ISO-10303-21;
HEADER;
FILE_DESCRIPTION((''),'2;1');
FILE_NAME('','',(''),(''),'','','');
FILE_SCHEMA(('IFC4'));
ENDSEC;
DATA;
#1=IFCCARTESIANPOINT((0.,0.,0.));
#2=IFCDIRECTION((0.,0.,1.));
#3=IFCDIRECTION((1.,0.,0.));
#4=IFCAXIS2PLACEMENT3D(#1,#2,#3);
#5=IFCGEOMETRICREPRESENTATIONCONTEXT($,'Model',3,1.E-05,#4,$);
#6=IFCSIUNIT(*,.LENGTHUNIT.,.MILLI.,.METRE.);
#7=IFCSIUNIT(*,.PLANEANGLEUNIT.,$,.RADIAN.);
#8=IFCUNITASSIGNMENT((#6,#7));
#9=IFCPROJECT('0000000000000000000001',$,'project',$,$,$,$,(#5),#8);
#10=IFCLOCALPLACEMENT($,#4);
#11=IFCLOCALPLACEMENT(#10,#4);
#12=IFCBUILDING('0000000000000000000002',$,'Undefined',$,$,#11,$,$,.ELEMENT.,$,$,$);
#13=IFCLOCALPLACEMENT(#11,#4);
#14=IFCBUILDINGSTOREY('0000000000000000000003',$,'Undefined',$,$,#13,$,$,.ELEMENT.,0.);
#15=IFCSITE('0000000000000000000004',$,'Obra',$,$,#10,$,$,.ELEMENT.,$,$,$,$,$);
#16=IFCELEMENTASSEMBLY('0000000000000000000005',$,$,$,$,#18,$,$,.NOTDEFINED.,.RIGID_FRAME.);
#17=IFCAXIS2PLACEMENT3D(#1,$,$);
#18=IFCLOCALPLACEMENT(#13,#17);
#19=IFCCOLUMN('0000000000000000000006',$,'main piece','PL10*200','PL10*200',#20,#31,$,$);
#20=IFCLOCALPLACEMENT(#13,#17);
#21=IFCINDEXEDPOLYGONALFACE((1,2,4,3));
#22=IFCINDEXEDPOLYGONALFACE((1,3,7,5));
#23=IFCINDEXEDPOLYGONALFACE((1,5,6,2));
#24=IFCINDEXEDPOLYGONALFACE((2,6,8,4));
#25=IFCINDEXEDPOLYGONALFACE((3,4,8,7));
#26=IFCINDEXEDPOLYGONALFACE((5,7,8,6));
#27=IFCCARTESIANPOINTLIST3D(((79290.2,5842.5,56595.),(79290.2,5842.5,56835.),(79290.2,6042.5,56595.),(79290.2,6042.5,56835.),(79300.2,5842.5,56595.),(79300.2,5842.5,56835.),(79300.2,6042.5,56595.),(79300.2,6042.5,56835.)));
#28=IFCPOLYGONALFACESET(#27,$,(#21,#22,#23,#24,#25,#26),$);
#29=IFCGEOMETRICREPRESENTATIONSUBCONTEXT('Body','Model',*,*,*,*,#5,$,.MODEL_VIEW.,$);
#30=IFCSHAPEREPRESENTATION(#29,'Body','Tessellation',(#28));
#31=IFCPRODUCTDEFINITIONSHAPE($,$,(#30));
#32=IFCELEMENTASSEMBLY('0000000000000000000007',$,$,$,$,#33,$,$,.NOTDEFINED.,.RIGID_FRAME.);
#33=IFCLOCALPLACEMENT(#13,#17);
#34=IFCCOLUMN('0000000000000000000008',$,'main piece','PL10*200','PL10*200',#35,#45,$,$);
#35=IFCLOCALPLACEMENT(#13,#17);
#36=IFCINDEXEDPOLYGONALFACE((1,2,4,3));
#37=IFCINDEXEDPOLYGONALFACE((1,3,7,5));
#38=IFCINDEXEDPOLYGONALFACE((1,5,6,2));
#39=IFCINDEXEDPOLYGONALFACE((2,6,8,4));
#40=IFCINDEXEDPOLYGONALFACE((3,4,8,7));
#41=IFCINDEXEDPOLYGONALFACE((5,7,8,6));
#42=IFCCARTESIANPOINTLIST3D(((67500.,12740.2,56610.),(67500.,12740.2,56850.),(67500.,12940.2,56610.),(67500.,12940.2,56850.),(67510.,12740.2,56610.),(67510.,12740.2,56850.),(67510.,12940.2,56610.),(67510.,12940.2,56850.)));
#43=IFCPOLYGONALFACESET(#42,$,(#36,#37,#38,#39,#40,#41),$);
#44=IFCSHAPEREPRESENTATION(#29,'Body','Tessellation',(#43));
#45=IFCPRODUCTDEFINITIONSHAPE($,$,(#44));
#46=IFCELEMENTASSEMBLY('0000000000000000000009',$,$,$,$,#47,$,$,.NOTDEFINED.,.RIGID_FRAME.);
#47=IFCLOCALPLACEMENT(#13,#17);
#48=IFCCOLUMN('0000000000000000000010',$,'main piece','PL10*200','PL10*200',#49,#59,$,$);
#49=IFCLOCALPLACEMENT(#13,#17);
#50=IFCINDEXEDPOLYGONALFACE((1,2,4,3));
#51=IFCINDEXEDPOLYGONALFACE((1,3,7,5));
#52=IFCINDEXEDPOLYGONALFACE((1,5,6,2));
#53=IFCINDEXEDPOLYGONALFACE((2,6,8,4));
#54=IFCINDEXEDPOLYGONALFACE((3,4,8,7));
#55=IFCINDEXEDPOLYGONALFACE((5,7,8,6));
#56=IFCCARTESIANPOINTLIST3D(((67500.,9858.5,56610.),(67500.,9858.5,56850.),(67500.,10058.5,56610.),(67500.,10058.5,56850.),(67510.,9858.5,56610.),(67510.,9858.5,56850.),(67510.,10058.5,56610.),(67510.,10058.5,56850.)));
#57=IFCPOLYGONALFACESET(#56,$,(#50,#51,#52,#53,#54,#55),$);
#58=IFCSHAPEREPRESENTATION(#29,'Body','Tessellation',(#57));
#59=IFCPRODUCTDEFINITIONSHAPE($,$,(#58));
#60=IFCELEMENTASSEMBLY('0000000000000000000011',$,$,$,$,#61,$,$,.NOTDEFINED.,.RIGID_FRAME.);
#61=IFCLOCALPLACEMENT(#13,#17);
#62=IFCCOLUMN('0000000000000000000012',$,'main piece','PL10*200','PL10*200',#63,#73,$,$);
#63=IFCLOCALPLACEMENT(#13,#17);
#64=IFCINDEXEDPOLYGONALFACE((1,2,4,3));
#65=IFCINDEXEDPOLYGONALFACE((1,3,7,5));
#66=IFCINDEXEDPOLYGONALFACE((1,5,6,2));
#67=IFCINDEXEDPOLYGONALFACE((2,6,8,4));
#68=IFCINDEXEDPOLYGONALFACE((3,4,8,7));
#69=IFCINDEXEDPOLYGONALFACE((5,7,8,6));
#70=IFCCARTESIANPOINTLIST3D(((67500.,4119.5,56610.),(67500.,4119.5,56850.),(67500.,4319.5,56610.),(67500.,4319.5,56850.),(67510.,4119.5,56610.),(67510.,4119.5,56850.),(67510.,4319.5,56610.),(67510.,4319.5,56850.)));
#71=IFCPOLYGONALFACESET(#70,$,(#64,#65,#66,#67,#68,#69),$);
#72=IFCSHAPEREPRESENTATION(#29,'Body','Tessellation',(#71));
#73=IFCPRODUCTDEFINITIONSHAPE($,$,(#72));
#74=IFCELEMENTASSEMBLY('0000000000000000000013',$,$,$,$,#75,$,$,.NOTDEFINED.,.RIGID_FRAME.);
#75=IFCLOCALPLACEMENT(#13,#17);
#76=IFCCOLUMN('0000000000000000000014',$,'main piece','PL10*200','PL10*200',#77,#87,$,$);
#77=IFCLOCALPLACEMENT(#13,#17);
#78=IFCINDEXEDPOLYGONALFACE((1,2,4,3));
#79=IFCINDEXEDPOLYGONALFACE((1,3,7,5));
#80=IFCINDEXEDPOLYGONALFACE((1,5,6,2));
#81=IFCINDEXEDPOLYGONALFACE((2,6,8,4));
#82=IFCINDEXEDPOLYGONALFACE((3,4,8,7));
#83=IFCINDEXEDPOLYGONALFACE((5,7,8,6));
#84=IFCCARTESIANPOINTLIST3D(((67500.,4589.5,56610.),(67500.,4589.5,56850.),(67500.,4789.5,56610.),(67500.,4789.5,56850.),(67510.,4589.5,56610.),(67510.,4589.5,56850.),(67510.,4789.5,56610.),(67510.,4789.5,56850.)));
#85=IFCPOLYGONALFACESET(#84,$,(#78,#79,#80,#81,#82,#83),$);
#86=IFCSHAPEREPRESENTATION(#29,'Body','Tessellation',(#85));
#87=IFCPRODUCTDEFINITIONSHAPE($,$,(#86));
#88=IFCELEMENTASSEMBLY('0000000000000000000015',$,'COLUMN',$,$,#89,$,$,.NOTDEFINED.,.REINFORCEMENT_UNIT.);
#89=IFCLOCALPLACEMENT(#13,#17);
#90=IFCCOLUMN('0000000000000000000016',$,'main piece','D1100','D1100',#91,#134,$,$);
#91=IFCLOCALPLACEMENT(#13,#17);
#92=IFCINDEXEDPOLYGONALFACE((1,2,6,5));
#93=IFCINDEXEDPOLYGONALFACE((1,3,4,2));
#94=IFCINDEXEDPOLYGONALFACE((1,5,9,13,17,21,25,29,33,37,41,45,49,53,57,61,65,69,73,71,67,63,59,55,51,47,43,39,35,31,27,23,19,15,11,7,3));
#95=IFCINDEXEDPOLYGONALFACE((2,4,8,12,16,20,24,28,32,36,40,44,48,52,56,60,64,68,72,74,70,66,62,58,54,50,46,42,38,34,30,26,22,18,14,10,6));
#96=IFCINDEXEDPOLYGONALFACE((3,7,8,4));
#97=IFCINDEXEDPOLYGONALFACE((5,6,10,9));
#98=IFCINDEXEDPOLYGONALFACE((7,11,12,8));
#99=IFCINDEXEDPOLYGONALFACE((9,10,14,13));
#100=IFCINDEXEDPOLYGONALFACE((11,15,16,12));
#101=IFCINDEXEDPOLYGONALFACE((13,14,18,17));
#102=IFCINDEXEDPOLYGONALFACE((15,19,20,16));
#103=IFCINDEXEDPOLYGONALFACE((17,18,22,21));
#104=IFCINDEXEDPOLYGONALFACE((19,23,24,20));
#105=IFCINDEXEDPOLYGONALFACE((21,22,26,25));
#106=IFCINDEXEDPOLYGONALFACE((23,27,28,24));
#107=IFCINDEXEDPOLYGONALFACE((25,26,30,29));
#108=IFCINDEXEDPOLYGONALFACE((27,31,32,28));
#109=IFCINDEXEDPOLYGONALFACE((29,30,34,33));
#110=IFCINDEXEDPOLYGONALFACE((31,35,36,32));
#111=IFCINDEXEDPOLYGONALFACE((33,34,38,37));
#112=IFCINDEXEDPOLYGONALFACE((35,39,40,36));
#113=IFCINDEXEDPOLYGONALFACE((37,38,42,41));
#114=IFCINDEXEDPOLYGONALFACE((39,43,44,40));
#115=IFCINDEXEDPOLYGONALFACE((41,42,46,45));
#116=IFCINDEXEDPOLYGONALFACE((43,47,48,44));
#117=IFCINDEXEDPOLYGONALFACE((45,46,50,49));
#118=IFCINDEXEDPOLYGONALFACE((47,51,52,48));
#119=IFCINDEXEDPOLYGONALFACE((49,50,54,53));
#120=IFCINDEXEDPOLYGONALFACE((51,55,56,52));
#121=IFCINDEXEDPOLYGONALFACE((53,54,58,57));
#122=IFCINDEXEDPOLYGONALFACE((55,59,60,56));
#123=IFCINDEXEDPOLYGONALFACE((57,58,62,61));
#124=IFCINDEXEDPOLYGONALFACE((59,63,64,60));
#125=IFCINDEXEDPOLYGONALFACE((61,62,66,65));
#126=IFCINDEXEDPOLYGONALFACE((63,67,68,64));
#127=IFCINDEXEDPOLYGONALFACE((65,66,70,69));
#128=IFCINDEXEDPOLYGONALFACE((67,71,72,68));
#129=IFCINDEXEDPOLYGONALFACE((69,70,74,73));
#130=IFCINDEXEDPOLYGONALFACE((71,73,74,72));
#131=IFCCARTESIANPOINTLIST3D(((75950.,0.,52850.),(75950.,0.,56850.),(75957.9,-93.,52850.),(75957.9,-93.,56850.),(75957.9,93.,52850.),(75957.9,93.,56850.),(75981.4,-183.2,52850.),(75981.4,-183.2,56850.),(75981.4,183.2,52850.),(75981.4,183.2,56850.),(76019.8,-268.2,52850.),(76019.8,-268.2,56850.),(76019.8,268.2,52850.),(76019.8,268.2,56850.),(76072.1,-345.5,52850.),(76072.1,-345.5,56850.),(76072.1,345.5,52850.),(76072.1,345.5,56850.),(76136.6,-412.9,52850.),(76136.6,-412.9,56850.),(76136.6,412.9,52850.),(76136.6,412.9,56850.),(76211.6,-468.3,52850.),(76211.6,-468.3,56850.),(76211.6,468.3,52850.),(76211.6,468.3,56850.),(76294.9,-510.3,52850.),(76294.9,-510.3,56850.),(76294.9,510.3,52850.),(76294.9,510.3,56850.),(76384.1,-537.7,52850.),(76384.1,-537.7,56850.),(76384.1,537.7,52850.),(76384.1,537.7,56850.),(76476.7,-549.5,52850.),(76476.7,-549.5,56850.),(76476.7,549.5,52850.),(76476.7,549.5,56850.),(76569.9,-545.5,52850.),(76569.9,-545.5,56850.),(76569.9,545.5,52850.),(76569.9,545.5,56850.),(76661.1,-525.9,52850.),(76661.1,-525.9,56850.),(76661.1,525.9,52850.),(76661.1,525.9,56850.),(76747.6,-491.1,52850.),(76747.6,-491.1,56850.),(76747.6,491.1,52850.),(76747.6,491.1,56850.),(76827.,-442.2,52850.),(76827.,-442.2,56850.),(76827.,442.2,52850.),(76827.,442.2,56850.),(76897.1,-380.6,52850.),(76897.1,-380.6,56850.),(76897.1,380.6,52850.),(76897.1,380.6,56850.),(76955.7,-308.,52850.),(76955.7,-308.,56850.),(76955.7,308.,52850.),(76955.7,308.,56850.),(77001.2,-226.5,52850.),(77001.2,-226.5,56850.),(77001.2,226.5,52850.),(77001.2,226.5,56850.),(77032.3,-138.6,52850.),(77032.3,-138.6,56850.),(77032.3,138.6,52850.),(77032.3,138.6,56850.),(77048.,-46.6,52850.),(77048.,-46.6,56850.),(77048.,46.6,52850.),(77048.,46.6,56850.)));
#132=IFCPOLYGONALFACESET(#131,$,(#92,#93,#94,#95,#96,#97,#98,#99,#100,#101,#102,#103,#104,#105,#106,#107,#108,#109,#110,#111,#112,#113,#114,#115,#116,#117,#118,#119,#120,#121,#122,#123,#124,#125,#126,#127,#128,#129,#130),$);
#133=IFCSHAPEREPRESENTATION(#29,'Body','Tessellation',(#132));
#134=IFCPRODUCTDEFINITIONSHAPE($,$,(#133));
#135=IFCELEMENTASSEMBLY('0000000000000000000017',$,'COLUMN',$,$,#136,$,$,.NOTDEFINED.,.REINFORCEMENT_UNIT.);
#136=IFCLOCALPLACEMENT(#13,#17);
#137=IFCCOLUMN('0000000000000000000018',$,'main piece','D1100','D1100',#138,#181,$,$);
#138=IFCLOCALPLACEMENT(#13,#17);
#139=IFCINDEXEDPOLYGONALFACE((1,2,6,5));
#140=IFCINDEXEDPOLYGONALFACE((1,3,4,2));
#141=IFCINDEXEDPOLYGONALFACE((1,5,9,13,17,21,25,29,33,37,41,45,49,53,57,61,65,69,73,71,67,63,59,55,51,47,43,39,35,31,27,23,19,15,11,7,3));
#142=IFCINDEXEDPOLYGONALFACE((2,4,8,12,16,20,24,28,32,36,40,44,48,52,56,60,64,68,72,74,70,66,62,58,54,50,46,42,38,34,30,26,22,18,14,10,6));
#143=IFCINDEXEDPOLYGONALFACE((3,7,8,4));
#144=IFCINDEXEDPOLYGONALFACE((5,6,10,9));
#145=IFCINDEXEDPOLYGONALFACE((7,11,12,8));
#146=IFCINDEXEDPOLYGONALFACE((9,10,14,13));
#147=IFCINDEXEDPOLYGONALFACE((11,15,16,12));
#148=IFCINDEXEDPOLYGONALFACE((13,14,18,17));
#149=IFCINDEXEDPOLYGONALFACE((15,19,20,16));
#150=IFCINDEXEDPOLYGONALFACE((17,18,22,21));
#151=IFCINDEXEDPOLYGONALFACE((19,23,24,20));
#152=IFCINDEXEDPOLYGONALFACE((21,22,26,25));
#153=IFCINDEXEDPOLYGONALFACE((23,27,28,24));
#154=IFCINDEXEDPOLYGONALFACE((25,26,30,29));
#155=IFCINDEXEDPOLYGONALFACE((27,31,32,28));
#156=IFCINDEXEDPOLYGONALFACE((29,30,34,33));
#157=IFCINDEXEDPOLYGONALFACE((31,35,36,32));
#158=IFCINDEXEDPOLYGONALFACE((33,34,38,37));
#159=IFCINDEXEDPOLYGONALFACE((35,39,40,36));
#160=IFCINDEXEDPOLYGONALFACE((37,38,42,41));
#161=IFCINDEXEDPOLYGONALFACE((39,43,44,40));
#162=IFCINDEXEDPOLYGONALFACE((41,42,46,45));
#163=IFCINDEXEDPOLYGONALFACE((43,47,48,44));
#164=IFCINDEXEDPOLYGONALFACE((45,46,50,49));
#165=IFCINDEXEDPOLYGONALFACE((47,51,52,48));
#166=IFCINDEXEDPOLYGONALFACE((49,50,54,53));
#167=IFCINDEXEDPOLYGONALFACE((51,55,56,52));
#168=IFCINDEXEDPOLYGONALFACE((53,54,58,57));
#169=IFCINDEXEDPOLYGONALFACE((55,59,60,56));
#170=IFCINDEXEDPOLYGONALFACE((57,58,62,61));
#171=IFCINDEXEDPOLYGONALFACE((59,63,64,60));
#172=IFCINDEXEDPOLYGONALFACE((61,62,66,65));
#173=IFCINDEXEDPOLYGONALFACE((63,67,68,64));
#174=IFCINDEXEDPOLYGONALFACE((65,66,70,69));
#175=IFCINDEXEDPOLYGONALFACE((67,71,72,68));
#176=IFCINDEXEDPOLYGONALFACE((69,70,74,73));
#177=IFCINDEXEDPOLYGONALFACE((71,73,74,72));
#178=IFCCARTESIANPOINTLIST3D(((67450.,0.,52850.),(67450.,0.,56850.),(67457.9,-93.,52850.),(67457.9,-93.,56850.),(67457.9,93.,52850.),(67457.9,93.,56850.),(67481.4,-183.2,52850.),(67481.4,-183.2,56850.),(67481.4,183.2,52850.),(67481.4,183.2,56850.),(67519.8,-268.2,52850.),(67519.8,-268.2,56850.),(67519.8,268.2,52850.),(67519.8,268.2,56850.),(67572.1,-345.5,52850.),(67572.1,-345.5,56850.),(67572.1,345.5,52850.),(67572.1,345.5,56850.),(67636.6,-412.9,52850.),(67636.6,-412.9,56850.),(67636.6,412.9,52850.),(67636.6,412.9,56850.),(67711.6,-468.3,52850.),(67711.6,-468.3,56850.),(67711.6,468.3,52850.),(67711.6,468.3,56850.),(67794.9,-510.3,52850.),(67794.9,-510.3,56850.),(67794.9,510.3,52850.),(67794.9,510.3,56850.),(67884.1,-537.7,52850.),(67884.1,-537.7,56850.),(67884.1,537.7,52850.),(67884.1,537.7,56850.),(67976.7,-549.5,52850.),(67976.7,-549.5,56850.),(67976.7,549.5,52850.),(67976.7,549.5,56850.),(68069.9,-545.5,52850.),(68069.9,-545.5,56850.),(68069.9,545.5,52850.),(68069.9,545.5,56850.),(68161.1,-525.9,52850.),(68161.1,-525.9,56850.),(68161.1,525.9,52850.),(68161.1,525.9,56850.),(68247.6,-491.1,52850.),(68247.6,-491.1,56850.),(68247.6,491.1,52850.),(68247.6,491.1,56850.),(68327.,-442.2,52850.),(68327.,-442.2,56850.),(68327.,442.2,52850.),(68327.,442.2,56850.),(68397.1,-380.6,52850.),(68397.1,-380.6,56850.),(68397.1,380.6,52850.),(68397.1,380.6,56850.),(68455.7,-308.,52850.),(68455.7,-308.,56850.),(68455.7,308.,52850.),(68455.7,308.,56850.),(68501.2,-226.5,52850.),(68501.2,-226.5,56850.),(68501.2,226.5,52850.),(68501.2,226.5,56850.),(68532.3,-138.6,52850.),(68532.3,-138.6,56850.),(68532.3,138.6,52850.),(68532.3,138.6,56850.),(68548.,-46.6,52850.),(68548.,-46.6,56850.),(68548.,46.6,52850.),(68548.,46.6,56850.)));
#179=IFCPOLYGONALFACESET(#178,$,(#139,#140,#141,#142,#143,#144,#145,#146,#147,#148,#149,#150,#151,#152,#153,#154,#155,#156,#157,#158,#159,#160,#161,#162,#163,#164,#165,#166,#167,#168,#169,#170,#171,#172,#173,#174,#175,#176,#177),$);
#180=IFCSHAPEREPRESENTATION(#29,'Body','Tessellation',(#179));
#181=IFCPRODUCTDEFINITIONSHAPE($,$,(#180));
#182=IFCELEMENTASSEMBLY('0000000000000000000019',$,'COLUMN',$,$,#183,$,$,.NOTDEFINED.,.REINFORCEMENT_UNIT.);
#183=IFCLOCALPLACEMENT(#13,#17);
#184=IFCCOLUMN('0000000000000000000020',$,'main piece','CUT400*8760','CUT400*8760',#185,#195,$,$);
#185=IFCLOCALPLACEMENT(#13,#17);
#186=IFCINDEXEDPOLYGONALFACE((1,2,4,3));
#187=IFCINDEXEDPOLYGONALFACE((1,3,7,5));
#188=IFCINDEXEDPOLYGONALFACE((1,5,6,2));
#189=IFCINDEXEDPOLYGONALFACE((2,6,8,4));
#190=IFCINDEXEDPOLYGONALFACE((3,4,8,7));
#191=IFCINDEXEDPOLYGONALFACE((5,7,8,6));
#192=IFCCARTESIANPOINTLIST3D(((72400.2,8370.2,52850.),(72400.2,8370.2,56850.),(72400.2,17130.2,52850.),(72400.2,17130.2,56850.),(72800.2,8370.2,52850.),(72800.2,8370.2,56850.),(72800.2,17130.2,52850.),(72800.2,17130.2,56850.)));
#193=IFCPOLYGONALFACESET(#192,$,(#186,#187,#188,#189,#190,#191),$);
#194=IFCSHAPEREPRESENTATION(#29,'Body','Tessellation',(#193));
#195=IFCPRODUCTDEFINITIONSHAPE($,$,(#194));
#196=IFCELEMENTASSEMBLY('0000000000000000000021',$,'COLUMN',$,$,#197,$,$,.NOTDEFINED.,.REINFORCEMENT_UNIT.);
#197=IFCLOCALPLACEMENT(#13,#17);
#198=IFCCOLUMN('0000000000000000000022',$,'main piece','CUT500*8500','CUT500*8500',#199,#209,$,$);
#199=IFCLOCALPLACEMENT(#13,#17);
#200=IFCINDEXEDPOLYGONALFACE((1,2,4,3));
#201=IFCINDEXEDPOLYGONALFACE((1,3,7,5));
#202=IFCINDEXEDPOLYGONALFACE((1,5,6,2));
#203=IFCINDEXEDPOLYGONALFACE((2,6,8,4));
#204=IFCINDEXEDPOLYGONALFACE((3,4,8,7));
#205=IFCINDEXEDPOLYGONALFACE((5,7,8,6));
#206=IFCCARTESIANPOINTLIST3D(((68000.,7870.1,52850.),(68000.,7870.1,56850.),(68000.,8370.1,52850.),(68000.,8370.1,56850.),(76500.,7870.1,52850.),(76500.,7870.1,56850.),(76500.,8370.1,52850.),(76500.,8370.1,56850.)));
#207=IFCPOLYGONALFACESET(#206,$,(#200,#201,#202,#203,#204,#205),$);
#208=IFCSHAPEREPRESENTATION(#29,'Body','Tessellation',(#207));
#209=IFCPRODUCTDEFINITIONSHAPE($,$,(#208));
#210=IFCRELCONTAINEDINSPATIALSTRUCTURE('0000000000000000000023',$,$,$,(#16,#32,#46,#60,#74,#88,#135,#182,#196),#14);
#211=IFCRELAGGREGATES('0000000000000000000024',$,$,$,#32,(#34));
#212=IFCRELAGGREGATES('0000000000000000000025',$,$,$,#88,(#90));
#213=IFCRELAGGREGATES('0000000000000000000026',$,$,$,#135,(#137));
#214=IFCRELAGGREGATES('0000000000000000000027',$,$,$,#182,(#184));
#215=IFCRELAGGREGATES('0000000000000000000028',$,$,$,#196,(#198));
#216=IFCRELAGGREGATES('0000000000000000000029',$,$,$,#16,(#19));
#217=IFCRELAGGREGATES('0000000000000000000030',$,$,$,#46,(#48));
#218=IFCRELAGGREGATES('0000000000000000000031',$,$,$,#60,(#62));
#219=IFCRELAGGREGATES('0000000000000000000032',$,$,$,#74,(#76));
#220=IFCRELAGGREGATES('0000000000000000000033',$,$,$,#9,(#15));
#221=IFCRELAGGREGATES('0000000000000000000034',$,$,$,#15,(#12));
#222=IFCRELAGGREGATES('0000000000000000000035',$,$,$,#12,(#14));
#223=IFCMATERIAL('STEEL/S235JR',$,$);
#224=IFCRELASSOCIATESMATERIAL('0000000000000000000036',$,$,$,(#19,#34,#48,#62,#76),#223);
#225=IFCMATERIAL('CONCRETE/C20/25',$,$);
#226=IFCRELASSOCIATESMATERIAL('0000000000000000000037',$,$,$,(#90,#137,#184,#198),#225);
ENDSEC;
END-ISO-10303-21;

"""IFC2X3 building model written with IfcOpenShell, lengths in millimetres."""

from ifc_helpers import new_model, si_unit, frame, origin_with_axes, origin_2d_with_axis, place, context, subcontext, project, spatial, rectangle, circle, extrude, material, element, aggregate, save


model = new_model("IFC2X3")

# Units and contexts
model_context = context("Model", 3, precision=1e-05, world=origin_with_axes())
body_context = subcontext(model_context, "Body", "Model", "MODEL_VIEW")
ifc_project = project(units=[si_unit("LENGTHUNIT", "METRE", prefix="MILLI"), si_unit("PLANEANGLEUNIT", "RADIAN")], contexts=[model_context])

# Site, building, storey
site_placement = place(None, origin_with_axes())
site = spatial("IfcSite", under=ifc_project, at=site_placement, Name="Obra", CompositionType="ELEMENT")
building_placement = place(site_placement, origin_with_axes())
building = spatial("IfcBuilding", under=site, at=building_placement, Name="Undefined", CompositionType="ELEMENT")
storey_placement = place(building_placement, origin_with_axes())
storey = spatial("IfcBuildingStorey", under=building, at=storey_placement, Name="Undefined", CompositionType="ELEMENT", Elevation=0.0)

# Element assemblies, columns
assembly_1_placement = place(storey_placement, origin_with_axes())
assembly_1 = element("IfcElementAssembly", 1, at=assembly_1_placement, inside=storey, AssemblyPlace="NOTDEFINED", PredefinedType="RIGID_FRAME")
ifc_material_1 = material(Name="STEEL/S235JR")
column_1_placement = place(assembly_1_placement, frame((79295.2, 5942.5, 56595.0), z_axis=(0.0, 0.0, 1.0), x_axis=(0.0, -1.0, 0.0)))
column_1 = element("IfcColumn", 2, at=column_1_placement, material=ifc_material_1, Name="main piece", Description="PL10*200", ObjectType="PL10*200", context=body_context, shape_type="SweptSolid", body=[
    extrude(rectangle(XDim=10.0, YDim=200.0, at=origin_2d_with_axis()), frame((0.0, 0.0, 240.0), z_axis=(0.0, 0.0, -1.0), x_axis=(0.0, 1.0, 0.0)), (0.0, 0.0, 1.0), 240.0),
])
assembly_2_placement = place(storey_placement, origin_with_axes())
assembly_2 = element("IfcElementAssembly", 3, at=assembly_2_placement, inside=storey, AssemblyPlace="NOTDEFINED", PredefinedType="RIGID_FRAME")
column_2_placement = place(assembly_2_placement, frame((67505.0, 12840.2, 56610.0), z_axis=(0.0, 0.0, 1.0), x_axis=(0.0, 1.0, 0.0)))
column_2 = element("IfcColumn", 4, at=column_2_placement, material=ifc_material_1, Name="main piece", Description="PL10*200", ObjectType="PL10*200", context=body_context, shape_type="SweptSolid", body=[
    extrude(rectangle(XDim=10.0, YDim=200.0, at=origin_2d_with_axis()), frame((0.0, 0.0, 240.0), z_axis=(0.0, 0.0, -1.0), x_axis=(0.0, 1.0, 0.0)), (0.0, 0.0, 1.0), 240.0),
])
aggregate(assembly_2, [column_2])
assembly_3_placement = place(storey_placement, origin_with_axes())
assembly_3 = element("IfcElementAssembly", 5, at=assembly_3_placement, inside=storey, AssemblyPlace="NOTDEFINED", PredefinedType="RIGID_FRAME")
column_3_placement = place(assembly_3_placement, frame((67505.0, 9958.5, 56610.0), z_axis=(0.0, 0.0, 1.0), x_axis=(0.0, 1.0, 0.0)))
column_3 = element("IfcColumn", 6, at=column_3_placement, material=ifc_material_1, Name="main piece", Description="PL10*200", ObjectType="PL10*200", context=body_context, shape_type="SweptSolid", body=[
    extrude(rectangle(XDim=10.0, YDim=200.0, at=origin_2d_with_axis()), frame((0.0, 0.0, 240.0), z_axis=(0.0, 0.0, -1.0), x_axis=(0.0, 1.0, 0.0)), (0.0, 0.0, 1.0), 240.0),
])
assembly_4_placement = place(storey_placement, origin_with_axes())
assembly_4 = element("IfcElementAssembly", 7, at=assembly_4_placement, inside=storey, AssemblyPlace="NOTDEFINED", PredefinedType="RIGID_FRAME")
column_4_placement = place(assembly_4_placement, frame((67505.0, 4219.5, 56610.0), z_axis=(0.0, 0.0, 1.0), x_axis=(0.0, 1.0, 0.0)))
column_4 = element("IfcColumn", 8, at=column_4_placement, material=ifc_material_1, Name="main piece", Description="PL10*200", ObjectType="PL10*200", context=body_context, shape_type="SweptSolid", body=[
    extrude(rectangle(XDim=10.0, YDim=200.0, at=origin_2d_with_axis()), frame((0.0, 0.0, 240.0), z_axis=(0.0, 0.0, -1.0), x_axis=(0.0, 1.0, 0.0)), (0.0, 0.0, 1.0), 240.0),
])
assembly_5_placement = place(storey_placement, origin_with_axes())
assembly_5 = element("IfcElementAssembly", 9, at=assembly_5_placement, inside=storey, AssemblyPlace="NOTDEFINED", PredefinedType="RIGID_FRAME")
column_5_placement = place(assembly_5_placement, frame((67505.0, 4689.5, 56610.0), z_axis=(0.0, 0.0, 1.0), x_axis=(0.0, 1.0, 0.0)))
column_5 = element("IfcColumn", 10, at=column_5_placement, material=ifc_material_1, Name="main piece", Description="PL10*200", ObjectType="PL10*200", context=body_context, shape_type="SweptSolid", body=[
    extrude(rectangle(XDim=10.0, YDim=200.0, at=origin_2d_with_axis()), frame((0.0, 0.0, 240.0), z_axis=(0.0, 0.0, -1.0), x_axis=(0.0, 1.0, 0.0)), (0.0, 0.0, 1.0), 240.0),
])
assembly_6_placement = place(storey_placement, origin_with_axes())
assembly_6 = element("IfcElementAssembly", 11, at=assembly_6_placement, inside=storey, Name="COLUMN", AssemblyPlace="NOTDEFINED", PredefinedType="REINFORCEMENT_UNIT")
ifc_material_2 = material(Name="CONCRETE/C20/25")
column_6_placement = place(assembly_6_placement, frame((76500.0, 0.0, 52850.0), z_axis=(0.0, 0.0, 1.0), x_axis=(0.0, 1.0, 0.0)))
column_6 = element("IfcColumn", 12, at=column_6_placement, material=ifc_material_2, Name="main piece", Description="D1100", ObjectType="D1100", context=body_context, shape_type="SweptSolid", body=[
    extrude(circle(Radius=550.0, at=origin_2d_with_axis()), frame((0.0, 0.0, 4000.0), z_axis=(0.0, 0.0, -1.0), x_axis=(0.0, 1.0, 0.0)), (0.0, 0.0, 1.0), 4000.0),
])
aggregate(assembly_6, [column_6])
assembly_7_placement = place(storey_placement, origin_with_axes())
assembly_7 = element("IfcElementAssembly", 13, at=assembly_7_placement, inside=storey, Name="COLUMN", AssemblyPlace="NOTDEFINED", PredefinedType="REINFORCEMENT_UNIT")
column_7_placement = place(assembly_7_placement, frame((68000.0, 0.0, 52850.0), z_axis=(0.0, 0.0, 1.0), x_axis=(0.0, 1.0, 0.0)))
column_7 = element("IfcColumn", 14, at=column_7_placement, material=ifc_material_2, Name="main piece", Description="D1100", ObjectType="D1100", context=body_context, shape_type="SweptSolid", body=[
    extrude(circle(Radius=550.0, at=origin_2d_with_axis()), frame((0.0, 0.0, 4000.0), z_axis=(0.0, 0.0, -1.0), x_axis=(0.0, 1.0, 0.0)), (0.0, 0.0, 1.0), 4000.0),
])
aggregate(assembly_7, [column_7])
assembly_8_placement = place(storey_placement, origin_with_axes())
assembly_8 = element("IfcElementAssembly", 15, at=assembly_8_placement, inside=storey, Name="COLUMN", AssemblyPlace="NOTDEFINED", PredefinedType="REINFORCEMENT_UNIT")
column_8_placement = place(assembly_8_placement, frame((72600.2, 12750.2, 52850.0), z_axis=(0.0, 0.0, 1.0), x_axis=(0.0, -1.0, 0.0)))
column_8 = element("IfcColumn", 16, at=column_8_placement, material=ifc_material_2, Name="main piece", Description="CUT400*8760", ObjectType="CUT400*8760", context=body_context, shape_type="SweptSolid", body=[
    extrude(rectangle(XDim=400.0, YDim=8760.0, at=origin_2d_with_axis()), frame((0.0, 0.0, 4000.0), z_axis=(0.0, 0.0, -1.0), x_axis=(0.0, 1.0, 0.0)), (0.0, 0.0, 1.0), 4000.0),
])
aggregate(assembly_8, [column_8])
assembly_9_placement = place(storey_placement, origin_with_axes())
assembly_9 = element("IfcElementAssembly", 17, at=assembly_9_placement, inside=storey, Name="COLUMN", AssemblyPlace="NOTDEFINED", PredefinedType="REINFORCEMENT_UNIT")
column_9_placement = place(assembly_9_placement, frame((72250.0, 8120.1, 52850.0), z_axis=(0.0, 0.0, 1.0), x_axis=(-1.0, 0.0, 0.0)))
column_9 = element("IfcColumn", 18, at=column_9_placement, material=ifc_material_2, Name="main piece", Description="CUT500*8500", ObjectType="CUT500*8500", context=body_context, shape_type="SweptSolid", body=[
    extrude(rectangle(XDim=500.0, YDim=8500.0, at=origin_2d_with_axis()), frame((0.0, 0.0, 4000.0), z_axis=(0.0, 0.0, -1.0), x_axis=(0.0, 1.0, 0.0)), (0.0, 0.0, 1.0), 4000.0),
])
aggregate(assembly_9, [column_9])

aggregate(assembly_1, [column_1])
aggregate(assembly_3, [column_3])
aggregate(assembly_4, [column_4])
aggregate(assembly_5, [column_5])

save(model, "model.ifc")
